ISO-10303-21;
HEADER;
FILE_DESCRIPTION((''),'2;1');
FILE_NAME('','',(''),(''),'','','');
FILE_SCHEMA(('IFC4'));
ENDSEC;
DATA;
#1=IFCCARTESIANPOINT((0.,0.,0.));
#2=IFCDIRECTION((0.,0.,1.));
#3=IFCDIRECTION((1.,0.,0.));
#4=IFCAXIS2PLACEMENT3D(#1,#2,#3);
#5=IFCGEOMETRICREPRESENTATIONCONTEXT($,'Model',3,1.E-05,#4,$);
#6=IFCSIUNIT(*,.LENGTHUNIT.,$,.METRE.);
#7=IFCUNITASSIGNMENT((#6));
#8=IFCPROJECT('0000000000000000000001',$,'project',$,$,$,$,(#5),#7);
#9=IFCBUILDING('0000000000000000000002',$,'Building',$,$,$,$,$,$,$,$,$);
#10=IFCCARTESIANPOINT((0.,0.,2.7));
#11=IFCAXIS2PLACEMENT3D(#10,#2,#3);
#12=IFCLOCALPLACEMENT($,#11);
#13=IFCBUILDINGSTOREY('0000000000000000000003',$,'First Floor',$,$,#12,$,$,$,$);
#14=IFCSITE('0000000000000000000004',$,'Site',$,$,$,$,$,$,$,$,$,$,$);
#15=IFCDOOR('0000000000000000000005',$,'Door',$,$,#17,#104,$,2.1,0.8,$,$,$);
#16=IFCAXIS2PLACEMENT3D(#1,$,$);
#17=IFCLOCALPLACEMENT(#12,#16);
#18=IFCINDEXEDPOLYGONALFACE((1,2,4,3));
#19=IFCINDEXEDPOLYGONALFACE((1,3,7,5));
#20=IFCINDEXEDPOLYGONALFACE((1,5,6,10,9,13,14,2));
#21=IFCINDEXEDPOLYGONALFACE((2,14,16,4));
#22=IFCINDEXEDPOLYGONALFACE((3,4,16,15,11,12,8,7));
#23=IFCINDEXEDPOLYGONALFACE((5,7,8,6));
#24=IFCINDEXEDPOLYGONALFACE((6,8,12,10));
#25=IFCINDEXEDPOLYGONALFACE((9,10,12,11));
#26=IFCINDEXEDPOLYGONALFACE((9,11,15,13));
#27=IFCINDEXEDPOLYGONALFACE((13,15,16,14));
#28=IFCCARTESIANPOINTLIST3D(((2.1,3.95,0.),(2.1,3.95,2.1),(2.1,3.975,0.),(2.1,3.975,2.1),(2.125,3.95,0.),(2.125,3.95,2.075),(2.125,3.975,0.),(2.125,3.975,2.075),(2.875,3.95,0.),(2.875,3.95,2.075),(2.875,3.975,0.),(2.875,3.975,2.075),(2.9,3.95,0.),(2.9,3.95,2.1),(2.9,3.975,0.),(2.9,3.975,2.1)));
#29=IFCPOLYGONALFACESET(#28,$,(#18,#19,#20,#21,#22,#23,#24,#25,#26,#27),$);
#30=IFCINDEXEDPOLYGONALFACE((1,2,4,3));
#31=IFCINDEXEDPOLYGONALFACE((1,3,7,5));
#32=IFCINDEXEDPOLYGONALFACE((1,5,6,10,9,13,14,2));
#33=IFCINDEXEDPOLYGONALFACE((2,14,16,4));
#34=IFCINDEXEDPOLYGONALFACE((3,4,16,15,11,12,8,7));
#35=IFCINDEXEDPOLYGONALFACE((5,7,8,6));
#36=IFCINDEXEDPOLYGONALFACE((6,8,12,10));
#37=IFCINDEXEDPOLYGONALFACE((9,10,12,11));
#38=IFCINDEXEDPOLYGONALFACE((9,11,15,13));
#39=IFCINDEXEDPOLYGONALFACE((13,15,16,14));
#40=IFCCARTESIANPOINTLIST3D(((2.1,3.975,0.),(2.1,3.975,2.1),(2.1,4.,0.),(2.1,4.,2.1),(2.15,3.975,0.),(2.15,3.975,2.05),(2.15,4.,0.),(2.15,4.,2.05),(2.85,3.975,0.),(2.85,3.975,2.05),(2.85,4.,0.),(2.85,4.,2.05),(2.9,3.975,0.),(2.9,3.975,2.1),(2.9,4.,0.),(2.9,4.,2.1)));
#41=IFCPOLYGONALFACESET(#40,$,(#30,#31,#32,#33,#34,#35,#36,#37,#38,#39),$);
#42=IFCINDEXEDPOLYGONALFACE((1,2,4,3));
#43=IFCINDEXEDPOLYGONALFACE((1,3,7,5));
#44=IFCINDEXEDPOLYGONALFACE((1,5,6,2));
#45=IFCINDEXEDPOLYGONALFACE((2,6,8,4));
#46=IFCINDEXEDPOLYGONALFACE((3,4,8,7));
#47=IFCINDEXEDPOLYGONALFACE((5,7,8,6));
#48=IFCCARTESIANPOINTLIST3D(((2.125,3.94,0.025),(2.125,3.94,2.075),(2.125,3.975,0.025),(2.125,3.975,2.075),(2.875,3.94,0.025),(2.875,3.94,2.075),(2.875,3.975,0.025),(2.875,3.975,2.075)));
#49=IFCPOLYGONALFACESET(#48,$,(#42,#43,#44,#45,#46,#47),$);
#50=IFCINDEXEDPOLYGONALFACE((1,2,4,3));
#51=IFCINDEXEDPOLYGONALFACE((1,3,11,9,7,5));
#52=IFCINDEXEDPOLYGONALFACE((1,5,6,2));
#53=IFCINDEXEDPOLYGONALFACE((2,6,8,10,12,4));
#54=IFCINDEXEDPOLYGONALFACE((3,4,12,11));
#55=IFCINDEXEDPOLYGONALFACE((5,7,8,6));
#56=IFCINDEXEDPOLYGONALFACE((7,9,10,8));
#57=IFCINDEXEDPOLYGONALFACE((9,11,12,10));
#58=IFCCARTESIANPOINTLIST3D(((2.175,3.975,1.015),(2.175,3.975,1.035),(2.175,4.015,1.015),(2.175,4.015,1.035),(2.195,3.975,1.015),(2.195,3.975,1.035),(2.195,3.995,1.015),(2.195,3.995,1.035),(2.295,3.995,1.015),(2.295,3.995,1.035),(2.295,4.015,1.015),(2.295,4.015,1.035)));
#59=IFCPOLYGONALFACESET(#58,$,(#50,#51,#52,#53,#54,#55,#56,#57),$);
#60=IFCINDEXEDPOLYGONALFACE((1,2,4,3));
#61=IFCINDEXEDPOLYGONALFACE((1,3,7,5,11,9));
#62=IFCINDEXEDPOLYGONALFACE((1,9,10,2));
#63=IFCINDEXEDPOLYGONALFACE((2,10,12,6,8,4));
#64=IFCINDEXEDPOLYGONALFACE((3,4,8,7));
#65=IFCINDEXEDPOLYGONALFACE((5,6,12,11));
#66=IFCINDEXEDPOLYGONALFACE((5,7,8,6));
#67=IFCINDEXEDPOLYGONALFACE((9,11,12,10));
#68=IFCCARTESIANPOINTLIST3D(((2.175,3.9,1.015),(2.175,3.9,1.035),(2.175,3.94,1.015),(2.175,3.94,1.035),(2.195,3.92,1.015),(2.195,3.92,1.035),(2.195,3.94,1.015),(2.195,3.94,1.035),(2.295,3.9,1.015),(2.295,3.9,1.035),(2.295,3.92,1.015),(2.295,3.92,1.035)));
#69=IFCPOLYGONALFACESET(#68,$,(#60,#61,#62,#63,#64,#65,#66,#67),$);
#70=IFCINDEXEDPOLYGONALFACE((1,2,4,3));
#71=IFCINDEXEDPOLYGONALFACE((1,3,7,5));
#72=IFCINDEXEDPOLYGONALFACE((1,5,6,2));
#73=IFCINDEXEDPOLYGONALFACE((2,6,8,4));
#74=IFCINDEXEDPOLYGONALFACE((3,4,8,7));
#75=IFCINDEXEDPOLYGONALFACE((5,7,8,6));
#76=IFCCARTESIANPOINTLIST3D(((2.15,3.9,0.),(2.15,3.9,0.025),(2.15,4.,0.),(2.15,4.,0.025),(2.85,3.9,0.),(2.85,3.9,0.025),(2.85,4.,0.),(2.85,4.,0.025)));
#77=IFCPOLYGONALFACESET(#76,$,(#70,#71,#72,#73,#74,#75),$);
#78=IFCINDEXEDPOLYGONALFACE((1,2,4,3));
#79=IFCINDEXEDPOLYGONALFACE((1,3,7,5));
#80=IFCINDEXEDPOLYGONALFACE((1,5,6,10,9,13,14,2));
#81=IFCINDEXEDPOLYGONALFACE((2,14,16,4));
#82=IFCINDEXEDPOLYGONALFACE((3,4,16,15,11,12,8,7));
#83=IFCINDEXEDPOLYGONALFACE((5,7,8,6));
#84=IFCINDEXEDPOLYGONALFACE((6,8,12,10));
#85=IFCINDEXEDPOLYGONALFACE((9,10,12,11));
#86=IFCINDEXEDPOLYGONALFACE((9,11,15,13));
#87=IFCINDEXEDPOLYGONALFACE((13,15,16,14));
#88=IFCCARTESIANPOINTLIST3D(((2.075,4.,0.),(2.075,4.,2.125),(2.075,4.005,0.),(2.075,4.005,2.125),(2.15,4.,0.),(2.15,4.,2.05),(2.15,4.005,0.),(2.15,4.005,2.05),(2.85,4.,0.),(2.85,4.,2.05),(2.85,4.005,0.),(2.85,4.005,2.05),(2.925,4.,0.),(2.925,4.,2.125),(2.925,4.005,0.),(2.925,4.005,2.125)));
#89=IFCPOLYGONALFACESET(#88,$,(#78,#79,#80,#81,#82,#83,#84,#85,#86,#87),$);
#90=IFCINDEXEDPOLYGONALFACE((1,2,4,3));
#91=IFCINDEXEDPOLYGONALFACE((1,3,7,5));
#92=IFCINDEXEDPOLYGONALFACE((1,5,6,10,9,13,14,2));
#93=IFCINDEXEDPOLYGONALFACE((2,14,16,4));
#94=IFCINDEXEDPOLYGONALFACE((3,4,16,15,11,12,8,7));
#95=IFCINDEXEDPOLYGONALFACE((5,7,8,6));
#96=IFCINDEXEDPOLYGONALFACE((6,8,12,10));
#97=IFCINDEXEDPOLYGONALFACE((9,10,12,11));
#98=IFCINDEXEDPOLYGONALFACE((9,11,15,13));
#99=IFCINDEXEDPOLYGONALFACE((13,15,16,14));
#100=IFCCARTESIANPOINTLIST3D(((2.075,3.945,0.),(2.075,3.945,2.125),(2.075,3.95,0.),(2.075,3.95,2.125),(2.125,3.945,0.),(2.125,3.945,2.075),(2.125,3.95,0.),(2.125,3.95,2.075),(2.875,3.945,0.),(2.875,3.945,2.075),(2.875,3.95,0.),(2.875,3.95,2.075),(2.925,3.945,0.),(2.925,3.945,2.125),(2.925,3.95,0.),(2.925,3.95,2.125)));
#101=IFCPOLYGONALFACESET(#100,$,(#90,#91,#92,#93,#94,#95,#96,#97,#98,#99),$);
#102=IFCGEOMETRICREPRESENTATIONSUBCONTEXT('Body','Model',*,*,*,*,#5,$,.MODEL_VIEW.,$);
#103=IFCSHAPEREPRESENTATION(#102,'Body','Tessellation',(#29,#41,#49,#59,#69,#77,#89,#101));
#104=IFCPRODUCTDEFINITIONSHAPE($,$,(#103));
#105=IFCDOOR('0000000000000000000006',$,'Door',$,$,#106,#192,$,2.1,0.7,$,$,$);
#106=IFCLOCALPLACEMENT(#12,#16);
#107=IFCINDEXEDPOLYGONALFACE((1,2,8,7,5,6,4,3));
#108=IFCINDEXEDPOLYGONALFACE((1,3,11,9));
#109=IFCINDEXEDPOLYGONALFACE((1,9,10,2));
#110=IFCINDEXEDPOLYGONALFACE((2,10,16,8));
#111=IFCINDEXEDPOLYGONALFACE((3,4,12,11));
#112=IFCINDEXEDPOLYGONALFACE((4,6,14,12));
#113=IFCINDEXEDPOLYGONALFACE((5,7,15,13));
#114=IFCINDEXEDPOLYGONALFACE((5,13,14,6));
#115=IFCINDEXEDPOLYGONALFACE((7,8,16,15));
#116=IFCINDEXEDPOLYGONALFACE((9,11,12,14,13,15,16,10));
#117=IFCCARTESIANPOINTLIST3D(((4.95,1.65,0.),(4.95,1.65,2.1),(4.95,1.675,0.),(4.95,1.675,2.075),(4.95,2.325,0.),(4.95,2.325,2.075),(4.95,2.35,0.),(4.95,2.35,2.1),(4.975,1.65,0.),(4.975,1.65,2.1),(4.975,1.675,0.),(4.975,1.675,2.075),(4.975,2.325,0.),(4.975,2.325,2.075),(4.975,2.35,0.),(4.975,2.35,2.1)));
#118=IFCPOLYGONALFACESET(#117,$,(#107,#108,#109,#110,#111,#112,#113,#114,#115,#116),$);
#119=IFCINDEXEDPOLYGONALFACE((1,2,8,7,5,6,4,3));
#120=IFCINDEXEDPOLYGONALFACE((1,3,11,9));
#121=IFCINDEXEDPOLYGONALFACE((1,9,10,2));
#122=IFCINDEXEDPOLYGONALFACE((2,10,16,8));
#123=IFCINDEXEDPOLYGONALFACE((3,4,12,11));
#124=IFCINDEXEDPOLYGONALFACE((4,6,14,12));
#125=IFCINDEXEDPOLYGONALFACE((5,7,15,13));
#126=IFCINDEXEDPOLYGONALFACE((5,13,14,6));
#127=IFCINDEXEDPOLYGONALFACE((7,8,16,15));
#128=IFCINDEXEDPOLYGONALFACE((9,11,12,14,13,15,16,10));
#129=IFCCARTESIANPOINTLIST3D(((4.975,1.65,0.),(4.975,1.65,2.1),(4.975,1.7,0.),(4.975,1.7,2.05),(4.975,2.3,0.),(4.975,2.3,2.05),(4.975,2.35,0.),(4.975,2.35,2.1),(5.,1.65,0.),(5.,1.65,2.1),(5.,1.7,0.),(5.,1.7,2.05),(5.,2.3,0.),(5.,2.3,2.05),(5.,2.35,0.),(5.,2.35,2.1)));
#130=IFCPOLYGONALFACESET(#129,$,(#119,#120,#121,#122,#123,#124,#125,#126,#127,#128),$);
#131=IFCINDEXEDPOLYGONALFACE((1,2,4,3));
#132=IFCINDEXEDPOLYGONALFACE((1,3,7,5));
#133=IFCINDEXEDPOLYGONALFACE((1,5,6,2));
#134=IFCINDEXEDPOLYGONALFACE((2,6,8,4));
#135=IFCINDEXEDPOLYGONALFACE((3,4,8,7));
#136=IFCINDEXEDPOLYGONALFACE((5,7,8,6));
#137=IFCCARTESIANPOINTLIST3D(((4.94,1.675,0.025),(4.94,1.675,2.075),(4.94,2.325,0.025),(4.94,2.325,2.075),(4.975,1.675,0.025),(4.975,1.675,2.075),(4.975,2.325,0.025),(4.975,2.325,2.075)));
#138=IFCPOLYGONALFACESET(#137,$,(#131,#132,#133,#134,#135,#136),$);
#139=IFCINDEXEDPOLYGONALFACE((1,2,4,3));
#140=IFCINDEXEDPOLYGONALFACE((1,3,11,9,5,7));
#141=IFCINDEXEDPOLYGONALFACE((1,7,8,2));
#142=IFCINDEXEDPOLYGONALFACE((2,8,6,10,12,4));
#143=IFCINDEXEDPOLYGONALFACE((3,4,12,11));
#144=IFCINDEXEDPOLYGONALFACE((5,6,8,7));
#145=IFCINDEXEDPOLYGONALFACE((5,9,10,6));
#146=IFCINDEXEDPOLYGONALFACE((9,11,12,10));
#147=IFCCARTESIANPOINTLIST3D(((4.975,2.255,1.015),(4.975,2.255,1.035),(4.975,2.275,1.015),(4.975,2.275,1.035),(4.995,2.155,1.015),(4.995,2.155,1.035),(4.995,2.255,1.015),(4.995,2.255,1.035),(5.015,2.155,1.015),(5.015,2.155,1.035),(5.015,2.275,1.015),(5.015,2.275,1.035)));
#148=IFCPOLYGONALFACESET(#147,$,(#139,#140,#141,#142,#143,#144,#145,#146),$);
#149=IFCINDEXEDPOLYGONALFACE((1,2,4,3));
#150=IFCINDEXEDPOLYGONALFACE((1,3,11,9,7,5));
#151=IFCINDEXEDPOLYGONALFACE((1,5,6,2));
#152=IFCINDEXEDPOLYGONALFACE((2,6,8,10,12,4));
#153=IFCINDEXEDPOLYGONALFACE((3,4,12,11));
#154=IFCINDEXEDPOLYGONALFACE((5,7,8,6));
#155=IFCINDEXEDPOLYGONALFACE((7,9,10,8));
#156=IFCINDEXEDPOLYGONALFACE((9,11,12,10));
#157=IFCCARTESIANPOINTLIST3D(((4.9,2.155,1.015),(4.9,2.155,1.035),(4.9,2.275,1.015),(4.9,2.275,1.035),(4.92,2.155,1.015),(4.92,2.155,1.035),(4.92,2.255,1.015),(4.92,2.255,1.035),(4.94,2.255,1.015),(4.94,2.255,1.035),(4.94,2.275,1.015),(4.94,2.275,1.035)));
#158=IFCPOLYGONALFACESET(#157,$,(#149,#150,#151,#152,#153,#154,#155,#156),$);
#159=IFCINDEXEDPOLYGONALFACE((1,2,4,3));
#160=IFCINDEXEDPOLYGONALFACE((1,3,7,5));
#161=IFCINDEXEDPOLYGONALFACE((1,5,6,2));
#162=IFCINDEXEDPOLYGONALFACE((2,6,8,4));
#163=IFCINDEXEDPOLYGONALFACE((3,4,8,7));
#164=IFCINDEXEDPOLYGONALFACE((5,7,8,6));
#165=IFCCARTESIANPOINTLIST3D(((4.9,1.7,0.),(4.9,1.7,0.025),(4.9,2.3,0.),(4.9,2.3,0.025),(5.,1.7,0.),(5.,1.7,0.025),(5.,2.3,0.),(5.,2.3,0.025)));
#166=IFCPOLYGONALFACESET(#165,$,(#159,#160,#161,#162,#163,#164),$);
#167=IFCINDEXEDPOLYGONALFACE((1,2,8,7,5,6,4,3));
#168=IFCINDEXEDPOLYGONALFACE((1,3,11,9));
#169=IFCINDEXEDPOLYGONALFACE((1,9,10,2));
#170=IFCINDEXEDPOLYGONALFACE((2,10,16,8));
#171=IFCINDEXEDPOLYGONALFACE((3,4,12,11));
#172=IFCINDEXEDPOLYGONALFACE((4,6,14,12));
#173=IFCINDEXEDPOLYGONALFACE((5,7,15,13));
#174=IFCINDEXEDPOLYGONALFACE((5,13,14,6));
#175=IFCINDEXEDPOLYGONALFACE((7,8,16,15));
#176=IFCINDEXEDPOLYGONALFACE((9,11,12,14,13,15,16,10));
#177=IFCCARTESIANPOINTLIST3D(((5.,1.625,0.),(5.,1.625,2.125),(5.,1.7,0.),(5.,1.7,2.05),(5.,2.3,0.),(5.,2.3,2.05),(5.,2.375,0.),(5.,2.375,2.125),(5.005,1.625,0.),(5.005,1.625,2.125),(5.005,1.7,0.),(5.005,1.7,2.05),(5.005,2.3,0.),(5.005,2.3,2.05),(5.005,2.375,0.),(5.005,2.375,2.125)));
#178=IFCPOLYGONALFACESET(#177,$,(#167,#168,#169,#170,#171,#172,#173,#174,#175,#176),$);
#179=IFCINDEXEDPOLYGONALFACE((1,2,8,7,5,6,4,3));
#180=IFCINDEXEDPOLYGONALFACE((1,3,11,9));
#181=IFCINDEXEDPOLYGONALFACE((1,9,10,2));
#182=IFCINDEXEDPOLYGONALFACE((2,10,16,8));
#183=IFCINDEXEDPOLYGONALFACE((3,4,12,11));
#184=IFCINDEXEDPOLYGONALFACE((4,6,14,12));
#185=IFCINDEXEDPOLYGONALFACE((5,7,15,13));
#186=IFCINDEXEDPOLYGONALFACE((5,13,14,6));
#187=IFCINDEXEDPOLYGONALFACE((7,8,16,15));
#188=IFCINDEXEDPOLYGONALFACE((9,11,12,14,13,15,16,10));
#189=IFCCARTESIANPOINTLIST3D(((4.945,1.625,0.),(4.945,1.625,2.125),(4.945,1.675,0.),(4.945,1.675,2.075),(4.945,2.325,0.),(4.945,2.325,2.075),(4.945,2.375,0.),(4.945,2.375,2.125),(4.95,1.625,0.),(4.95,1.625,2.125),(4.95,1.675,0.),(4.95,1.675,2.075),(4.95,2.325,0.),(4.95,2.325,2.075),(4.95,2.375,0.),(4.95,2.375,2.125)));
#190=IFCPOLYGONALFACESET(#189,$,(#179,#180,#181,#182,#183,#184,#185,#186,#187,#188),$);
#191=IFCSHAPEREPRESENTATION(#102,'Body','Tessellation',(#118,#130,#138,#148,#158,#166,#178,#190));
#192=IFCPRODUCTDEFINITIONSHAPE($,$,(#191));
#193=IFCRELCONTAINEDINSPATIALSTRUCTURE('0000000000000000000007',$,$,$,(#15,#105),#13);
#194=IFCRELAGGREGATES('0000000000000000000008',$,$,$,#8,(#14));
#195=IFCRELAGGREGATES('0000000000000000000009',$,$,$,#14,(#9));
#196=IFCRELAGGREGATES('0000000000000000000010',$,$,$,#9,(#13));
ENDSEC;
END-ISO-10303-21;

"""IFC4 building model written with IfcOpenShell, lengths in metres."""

from ifc_helpers import new_model, si_unit, frame, origin_with_axes, place, context, subcontext, project, spatial, line, indexed_curve, outline, extrude, element, save


model = new_model("IFC4")

# Units and contexts
model_context = context("Model", 3, precision=1e-05, world=origin_with_axes())
body_context = subcontext(model_context, "Body", "Model", "MODEL_VIEW")
ifc_project = project(units=[si_unit("LENGTHUNIT", "METRE")], contexts=[model_context])

# Site, building, storey
site = spatial("IfcSite", under=ifc_project, Name="Site")
building = spatial("IfcBuilding", under=site, Name="Building")
storey_placement = place(None, frame((0.0, 0.0, 2.7), z_axis=(0.0, 0.0, 1.0), x_axis=(1.0, 0.0, 0.0)))
storey = spatial("IfcBuildingStorey", under=building, at=storey_placement, Name="First Floor")

# Doors
door_1_placement = place(storey_placement, frame((2.9, 4.0, 0.0), z_axis=(0.0, 0.0, 1.0), x_axis=(-1.0, 0.0, 0.0)))
element("IfcDoor", 1, at=door_1_placement, inside=storey, Name="Door", OverallHeight=2.1, OverallWidth=0.8, context=body_context, shape_type="SweptSolid", body=[
    extrude(outline(indexed_curve([(0.0, 0.0), (0.0, 2.1), (0.8, 2.1), (0.8, 0.0), (0.775, 0.0), (0.775, 2.075), (0.025, 2.075), (0.025, 0.0)], segments=[line(1, 2, 3, 4, 5, 6, 7, 8, 1)])), frame((0.0, 0.025, 0.0), z_axis=(0.0, -1.0, 0.0), x_axis=(1.0, 0.0, 0.0)), (0.0, 0.0, -1.0), 0.025),
    extrude(outline(indexed_curve([(0.0, 0.0), (0.0, 2.1), (0.8, 2.1), (0.8, 0.0), (0.75, 0.0), (0.75, 2.05), (0.05, 2.05), (0.05, 0.0)], segments=[line(1, 2, 3, 4, 5, 6, 7, 8, 1)])), frame((0.0, 0.0, 0.0), z_axis=(0.0, -1.0, 0.0), x_axis=(1.0, 0.0, 0.0)), (0.0, 0.0, -1.0), 0.025),
    extrude(outline(indexed_curve([(0.0, 0.0), (0.75, 0.0), (0.75, 0.035), (0.0, 0.035)], segments=[line(1, 2, 3, 4, 1)])), frame((0.025, 0.025, 0.025), z_axis=(0.0, 0.0, 1.0), x_axis=(1.0, 0.0, 0.0)), (0.0, 0.0, 1.0), 2.05),
    extrude(outline(indexed_curve([(0.0, 0.0), (0.0, -0.04), (-0.12, -0.04), (-0.12, -0.02), (-0.02, -0.02), (-0.02, 0.0)], segments=[line(1, 2, 3, 4, 5, 6, 1)])), frame((0.725, 0.025, 1.015), z_axis=(0.0, 0.0, 1.0), x_axis=(1.0, 0.0, 0.0)), (0.0, 0.0, 1.0), 0.02),
    extrude(outline(indexed_curve([(0.0, 0.0), (0.0, 0.04), (-0.12, 0.04), (-0.12, 0.02), (-0.02, 0.02), (-0.02, 0.0)], segments=[line(1, 2, 3, 4, 5, 6, 1)])), frame((0.725, 0.06, 1.015), z_axis=(0.0, 0.0, 1.0), x_axis=(1.0, 0.0, 0.0)), (0.0, 0.0, 1.0), 0.02),
    extrude(outline(indexed_curve([(0.0, 0.0), (0.7, 0.0), (0.7, 0.1), (0.0, 0.1)], segments=[line(1, 2, 3, 4, 1)])), frame((0.05, 0.0, 0.0), z_axis=(0.0, 0.0, 1.0), x_axis=(1.0, 0.0, 0.0)), (0.0, 0.0, 1.0), 0.025),
    extrude(outline(indexed_curve([(0.0, 0.0), (0.0, 2.125), (0.85, 2.125), (0.85, 0.0), (0.775, 0.0), (0.775, 2.05), (0.075, 2.05), (0.075, 0.0)], segments=[line(1, 2, 3, 4, 5, 6, 7, 8, 1)])), frame((-0.025, -0.005, 0.0), z_axis=(0.0, -1.0, 0.0), x_axis=(1.0, 0.0, 0.0)), (0.0, 0.0, -1.0), 0.005),
    extrude(outline(indexed_curve([(0.0, 0.0), (0.0, 2.125), (0.85, 2.125), (0.85, 0.0), (0.8, 0.0), (0.8, 2.075), (0.05, 2.075), (0.05, 0.0)], segments=[line(1, 2, 3, 4, 5, 6, 7, 8, 1)])), frame((-0.025, 0.05, 0.0), z_axis=(0.0, -1.0, 0.0), x_axis=(1.0, 0.0, 0.0)), (0.0, 0.0, -1.0), 0.005),
])
door_2_placement = place(storey_placement, frame((5.0, 1.65, 0.0), z_axis=(0.0, 0.0, 1.0), x_axis=(0.0, 1.0, 0.0)))
element("IfcDoor", 2, at=door_2_placement, inside=storey, Name="Door", OverallHeight=2.1, OverallWidth=0.7, context=body_context, shape_type="SweptSolid", body=[
    extrude(outline(indexed_curve([(0.0, 0.0), (0.0, 2.1), (0.7, 2.1), (0.7, 0.0), (0.675, 0.0), (0.675, 2.075), (0.025, 2.075), (0.025, 0.0)], segments=[line(1, 2, 3, 4, 5, 6, 7, 8, 1)])), frame((0.0, 0.025, 0.0), z_axis=(0.0, -1.0, 0.0), x_axis=(1.0, 0.0, 0.0)), (0.0, 0.0, -1.0), 0.025),
    extrude(outline(indexed_curve([(0.0, 0.0), (0.0, 2.1), (0.7, 2.1), (0.7, 0.0), (0.65, 0.0), (0.65, 2.05), (0.05, 2.05), (0.05, 0.0)], segments=[line(1, 2, 3, 4, 5, 6, 7, 8, 1)])), frame((0.0, 0.0, 0.0), z_axis=(0.0, -1.0, 0.0), x_axis=(1.0, 0.0, 0.0)), (0.0, 0.0, -1.0), 0.025),
    extrude(outline(indexed_curve([(0.0, 0.0), (0.65, 0.0), (0.65, 0.035), (0.0, 0.035)], segments=[line(1, 2, 3, 4, 1)])), frame((0.025, 0.025, 0.025), z_axis=(0.0, 0.0, 1.0), x_axis=(1.0, 0.0, 0.0)), (0.0, 0.0, 1.0), 2.05),
    extrude(outline(indexed_curve([(0.0, 0.0), (0.0, -0.04), (-0.12, -0.04), (-0.12, -0.02), (-0.02, -0.02), (-0.02, 0.0)], segments=[line(1, 2, 3, 4, 5, 6, 1)])), frame((0.625, 0.025, 1.015), z_axis=(0.0, 0.0, 1.0), x_axis=(1.0, 0.0, 0.0)), (0.0, 0.0, 1.0), 0.02),
    extrude(outline(indexed_curve([(0.0, 0.0), (0.0, 0.04), (-0.12, 0.04), (-0.12, 0.02), (-0.02, 0.02), (-0.02, 0.0)], segments=[line(1, 2, 3, 4, 5, 6, 1)])), frame((0.625, 0.06, 1.015), z_axis=(0.0, 0.0, 1.0), x_axis=(1.0, 0.0, 0.0)), (0.0, 0.0, 1.0), 0.02),
    extrude(outline(indexed_curve([(0.0, 0.0), (0.6, 0.0), (0.6, 0.1), (0.0, 0.1)], segments=[line(1, 2, 3, 4, 1)])), frame((0.05, 0.0, 0.0), z_axis=(0.0, 0.0, 1.0), x_axis=(1.0, 0.0, 0.0)), (0.0, 0.0, 1.0), 0.025),
    extrude(outline(indexed_curve([(0.0, 0.0), (0.0, 2.125), (0.75, 2.125), (0.75, 0.0), (0.675, 0.0), (0.675, 2.05), (0.075, 2.05), (0.075, 0.0)], segments=[line(1, 2, 3, 4, 5, 6, 7, 8, 1)])), frame((-0.025, -0.005, 0.0), z_axis=(0.0, -1.0, 0.0), x_axis=(1.0, 0.0, 0.0)), (0.0, 0.0, -1.0), 0.005),
    extrude(outline(indexed_curve([(0.0, 0.0), (0.0, 2.125), (0.75, 2.125), (0.75, 0.0), (0.7, 0.0), (0.7, 2.075), (0.05, 2.075), (0.05, 0.0)], segments=[line(1, 2, 3, 4, 5, 6, 7, 8, 1)])), frame((-0.025, 0.05, 0.0), z_axis=(0.0, -1.0, 0.0), x_axis=(1.0, 0.0, 0.0)), (0.0, 0.0, -1.0), 0.005),
])

save(model, "model.ifc")
